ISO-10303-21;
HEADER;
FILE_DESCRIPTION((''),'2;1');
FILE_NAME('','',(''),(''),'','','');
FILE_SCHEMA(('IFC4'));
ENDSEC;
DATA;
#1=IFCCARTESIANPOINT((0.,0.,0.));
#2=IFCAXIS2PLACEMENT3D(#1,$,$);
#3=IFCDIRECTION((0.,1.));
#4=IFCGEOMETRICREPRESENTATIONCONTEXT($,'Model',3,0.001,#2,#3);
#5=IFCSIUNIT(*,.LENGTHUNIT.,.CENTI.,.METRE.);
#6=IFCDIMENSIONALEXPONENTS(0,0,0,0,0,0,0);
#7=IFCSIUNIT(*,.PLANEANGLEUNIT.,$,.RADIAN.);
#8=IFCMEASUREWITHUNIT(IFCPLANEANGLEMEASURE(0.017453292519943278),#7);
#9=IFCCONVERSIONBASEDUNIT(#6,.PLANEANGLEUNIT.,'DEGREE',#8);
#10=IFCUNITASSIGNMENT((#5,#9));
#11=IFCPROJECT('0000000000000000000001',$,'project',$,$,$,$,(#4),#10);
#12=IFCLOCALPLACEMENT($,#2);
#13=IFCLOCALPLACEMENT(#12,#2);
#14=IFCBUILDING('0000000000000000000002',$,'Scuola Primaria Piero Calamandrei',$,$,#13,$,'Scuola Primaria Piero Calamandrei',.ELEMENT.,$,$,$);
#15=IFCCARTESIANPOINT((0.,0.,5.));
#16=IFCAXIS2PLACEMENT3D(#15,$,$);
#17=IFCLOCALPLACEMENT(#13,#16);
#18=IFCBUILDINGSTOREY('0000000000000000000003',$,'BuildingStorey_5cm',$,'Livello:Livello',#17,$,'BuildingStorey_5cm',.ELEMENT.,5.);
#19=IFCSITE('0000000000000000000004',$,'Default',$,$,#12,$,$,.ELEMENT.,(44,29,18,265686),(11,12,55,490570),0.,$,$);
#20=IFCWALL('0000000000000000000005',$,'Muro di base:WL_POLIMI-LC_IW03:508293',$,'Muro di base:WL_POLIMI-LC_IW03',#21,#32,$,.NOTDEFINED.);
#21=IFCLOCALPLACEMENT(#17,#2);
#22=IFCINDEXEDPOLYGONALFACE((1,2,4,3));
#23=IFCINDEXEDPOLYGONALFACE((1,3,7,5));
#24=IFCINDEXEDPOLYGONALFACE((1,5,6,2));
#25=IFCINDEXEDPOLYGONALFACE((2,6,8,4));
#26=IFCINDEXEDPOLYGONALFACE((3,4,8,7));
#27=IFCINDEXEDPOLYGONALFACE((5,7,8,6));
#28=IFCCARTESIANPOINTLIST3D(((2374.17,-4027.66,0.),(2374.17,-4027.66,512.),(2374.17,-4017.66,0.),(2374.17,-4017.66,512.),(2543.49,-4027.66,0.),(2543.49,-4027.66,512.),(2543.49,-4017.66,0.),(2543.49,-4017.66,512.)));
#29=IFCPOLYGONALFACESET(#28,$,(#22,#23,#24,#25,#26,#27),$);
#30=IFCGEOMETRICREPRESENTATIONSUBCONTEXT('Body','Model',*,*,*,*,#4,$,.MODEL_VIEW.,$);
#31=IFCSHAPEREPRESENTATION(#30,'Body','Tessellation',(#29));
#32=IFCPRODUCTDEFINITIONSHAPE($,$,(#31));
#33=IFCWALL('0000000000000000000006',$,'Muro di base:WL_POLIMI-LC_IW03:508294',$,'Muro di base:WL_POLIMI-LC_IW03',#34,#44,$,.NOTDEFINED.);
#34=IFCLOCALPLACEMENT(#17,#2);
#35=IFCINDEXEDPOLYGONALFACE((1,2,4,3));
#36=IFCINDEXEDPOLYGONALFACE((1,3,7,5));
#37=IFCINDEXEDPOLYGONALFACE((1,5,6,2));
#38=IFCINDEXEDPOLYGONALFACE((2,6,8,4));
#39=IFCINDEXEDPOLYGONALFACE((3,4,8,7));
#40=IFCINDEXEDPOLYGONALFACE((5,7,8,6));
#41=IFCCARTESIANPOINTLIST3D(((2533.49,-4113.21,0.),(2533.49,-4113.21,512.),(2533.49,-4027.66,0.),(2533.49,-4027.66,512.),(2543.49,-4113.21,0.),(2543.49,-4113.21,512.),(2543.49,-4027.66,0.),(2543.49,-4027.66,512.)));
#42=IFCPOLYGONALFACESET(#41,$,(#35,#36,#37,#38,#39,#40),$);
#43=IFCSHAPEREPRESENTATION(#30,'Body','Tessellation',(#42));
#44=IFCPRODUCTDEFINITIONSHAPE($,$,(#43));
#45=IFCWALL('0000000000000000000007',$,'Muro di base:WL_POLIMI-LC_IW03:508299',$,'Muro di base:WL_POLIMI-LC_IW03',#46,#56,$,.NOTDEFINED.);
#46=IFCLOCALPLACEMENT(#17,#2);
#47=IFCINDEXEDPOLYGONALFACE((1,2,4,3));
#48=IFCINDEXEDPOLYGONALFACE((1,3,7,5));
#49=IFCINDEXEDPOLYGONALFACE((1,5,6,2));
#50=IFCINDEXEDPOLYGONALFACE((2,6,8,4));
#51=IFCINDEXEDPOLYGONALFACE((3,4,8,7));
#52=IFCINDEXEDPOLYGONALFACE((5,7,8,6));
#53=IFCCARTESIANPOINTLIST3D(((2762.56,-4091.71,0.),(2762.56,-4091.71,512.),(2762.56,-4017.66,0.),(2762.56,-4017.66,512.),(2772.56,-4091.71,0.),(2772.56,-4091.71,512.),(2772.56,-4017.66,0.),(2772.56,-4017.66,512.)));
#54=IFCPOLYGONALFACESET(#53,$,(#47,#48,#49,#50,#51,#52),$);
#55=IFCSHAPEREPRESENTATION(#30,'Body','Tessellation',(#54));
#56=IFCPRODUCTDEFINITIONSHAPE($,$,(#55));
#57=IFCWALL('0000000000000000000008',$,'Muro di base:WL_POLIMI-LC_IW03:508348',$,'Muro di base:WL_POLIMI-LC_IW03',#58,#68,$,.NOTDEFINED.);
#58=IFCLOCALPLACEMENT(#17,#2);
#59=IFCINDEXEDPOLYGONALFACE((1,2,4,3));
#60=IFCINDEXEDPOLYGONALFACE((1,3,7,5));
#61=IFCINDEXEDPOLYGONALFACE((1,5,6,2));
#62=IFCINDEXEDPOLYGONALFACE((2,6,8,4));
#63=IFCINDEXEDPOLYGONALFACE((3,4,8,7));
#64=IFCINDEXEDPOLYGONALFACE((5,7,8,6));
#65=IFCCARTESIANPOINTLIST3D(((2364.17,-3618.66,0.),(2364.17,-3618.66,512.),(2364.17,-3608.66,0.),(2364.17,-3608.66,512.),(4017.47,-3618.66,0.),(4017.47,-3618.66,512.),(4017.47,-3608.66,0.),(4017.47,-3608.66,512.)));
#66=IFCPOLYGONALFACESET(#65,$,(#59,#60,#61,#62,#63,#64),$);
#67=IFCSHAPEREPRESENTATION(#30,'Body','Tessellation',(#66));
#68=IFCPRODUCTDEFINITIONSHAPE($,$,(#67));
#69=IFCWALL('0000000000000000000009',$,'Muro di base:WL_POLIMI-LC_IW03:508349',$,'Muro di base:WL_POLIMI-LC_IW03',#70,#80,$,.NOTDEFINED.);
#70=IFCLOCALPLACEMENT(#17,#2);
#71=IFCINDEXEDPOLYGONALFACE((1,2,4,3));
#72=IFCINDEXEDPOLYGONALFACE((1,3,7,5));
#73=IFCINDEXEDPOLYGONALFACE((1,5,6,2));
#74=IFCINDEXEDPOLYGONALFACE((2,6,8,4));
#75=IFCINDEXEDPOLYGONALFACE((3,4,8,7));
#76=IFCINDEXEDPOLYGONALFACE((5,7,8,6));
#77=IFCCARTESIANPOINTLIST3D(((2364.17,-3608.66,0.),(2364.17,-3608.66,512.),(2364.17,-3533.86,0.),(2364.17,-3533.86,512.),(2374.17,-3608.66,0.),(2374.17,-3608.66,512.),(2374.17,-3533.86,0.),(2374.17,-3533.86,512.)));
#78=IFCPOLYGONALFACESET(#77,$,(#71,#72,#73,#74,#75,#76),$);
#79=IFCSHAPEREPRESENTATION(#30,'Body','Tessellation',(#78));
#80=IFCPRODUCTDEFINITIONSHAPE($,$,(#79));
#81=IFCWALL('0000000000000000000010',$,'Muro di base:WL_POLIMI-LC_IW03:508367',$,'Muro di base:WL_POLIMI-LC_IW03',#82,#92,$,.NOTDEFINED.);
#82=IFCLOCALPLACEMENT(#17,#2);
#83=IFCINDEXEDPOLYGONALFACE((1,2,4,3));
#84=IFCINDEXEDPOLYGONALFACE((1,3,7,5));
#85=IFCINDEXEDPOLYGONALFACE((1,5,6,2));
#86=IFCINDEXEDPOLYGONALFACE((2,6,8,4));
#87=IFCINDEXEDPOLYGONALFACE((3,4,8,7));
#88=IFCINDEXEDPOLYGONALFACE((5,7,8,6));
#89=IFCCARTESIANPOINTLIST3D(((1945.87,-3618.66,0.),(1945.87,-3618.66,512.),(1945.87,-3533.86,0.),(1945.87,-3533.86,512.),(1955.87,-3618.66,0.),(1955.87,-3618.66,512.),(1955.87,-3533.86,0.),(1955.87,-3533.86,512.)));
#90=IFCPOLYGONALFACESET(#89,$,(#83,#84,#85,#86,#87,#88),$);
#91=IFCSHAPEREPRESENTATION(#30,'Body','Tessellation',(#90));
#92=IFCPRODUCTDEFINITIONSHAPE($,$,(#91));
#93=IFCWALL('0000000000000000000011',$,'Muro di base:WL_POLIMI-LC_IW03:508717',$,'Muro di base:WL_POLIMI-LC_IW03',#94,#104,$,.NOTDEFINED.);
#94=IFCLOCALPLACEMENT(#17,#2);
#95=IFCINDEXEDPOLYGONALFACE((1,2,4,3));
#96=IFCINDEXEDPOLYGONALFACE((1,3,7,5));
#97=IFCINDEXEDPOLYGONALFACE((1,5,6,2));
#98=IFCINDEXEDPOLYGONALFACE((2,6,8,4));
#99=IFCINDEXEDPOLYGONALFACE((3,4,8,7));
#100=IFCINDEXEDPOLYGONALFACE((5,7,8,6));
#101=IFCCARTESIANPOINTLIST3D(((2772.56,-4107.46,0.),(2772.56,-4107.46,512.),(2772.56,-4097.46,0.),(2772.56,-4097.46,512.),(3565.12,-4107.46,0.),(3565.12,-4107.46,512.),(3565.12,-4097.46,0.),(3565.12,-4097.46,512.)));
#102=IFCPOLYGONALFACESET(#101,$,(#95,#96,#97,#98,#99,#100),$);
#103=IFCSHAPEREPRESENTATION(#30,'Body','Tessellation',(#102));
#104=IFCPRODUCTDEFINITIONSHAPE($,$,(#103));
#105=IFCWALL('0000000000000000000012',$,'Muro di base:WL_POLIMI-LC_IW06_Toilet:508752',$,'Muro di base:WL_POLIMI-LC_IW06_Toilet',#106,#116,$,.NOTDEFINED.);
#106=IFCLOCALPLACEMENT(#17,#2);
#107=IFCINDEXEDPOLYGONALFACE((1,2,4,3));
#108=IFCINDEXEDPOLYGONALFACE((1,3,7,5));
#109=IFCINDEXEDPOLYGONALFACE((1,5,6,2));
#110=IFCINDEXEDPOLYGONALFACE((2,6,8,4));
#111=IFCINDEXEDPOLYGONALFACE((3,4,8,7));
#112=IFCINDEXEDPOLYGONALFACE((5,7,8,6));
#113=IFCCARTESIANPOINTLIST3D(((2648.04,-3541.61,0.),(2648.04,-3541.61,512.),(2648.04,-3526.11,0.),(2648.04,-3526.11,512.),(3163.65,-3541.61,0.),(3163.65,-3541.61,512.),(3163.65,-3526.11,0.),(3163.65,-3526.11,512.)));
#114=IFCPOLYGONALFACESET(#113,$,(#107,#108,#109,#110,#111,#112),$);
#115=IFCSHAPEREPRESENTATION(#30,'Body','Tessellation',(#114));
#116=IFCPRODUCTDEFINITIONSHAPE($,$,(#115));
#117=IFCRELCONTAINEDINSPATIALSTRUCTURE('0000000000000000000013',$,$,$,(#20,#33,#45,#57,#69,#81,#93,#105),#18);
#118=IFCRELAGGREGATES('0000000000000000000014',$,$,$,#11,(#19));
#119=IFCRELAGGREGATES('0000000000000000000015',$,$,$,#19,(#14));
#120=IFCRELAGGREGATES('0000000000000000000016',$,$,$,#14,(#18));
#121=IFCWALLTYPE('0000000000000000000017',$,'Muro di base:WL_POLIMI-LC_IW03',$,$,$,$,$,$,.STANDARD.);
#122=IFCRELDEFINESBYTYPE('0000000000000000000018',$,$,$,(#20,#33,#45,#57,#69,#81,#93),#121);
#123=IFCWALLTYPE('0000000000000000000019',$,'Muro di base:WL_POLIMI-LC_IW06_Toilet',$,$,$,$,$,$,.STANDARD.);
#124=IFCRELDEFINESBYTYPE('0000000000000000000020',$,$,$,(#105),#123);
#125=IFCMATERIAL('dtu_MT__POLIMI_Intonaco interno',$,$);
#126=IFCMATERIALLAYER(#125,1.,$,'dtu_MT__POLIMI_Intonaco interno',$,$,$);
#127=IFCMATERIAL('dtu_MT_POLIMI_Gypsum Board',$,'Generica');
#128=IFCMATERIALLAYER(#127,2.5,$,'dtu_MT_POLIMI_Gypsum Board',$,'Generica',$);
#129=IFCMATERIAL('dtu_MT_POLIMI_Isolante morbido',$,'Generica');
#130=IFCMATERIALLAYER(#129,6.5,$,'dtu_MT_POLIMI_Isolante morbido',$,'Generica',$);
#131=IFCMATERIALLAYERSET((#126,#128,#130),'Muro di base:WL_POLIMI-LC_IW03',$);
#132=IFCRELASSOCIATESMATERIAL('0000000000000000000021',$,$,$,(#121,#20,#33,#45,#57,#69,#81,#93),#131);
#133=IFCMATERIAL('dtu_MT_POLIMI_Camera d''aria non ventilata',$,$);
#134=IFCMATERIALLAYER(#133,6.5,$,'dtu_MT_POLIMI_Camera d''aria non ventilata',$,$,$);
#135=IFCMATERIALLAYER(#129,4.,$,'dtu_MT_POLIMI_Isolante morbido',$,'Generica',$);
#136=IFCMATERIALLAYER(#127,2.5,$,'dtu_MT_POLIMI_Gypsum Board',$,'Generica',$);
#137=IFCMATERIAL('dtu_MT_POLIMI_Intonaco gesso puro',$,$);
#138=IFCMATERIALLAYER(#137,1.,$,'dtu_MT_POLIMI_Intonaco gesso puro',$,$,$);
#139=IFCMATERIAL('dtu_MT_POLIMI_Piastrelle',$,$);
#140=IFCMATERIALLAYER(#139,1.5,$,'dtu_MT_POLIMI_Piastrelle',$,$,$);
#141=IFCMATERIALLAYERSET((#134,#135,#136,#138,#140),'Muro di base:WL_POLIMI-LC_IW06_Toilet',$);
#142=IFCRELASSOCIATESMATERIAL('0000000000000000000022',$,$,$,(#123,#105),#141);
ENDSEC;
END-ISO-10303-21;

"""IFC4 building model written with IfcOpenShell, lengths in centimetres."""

from ifc_helpers import new_model, entity, si_unit, converted_unit, direction, frame, frame_2d, origin, place, context, subcontext, project, spatial, rectangle, extrude, material, layer, layer_set, layer_usage, type_object, element, save


model = new_model("IFC4")

# Units and contexts
model_context = context("Model", 3, precision=0.001, world=origin(), true_north=direction((0.0, 1.0)))
body_context = subcontext(model_context, "Body", "Model", "MODEL_VIEW")
ifc_project = project(units=[si_unit("LENGTHUNIT", "METRE", prefix="CENTI"), converted_unit("PLANEANGLEUNIT", "DEGREE", entity("IfcPlaneAngleMeasure", 0.017453292519943278), si_unit("PLANEANGLEUNIT", "RADIAN"), dimensions=[0, 0, 0, 0, 0, 0, 0])], contexts=[model_context])

# Site, building, storey
site_placement = place(None, origin())
site = spatial("IfcSite", under=ifc_project, at=site_placement, Name="Default", CompositionType="ELEMENT", RefLatitude=(44, 29, 18, 265686), RefLongitude=(11, 12, 55, 490570), RefElevation=0.0)
building_placement = place(site_placement, origin())
building = spatial("IfcBuilding", under=site, at=building_placement, Name="Scuola Primaria Piero Calamandrei", LongName="Scuola Primaria Piero Calamandrei", CompositionType="ELEMENT")
storey_placement = place(building_placement, frame((0.0, 0.0, 5.0)))
storey = spatial("IfcBuildingStorey", under=building, at=storey_placement, Name="BuildingStorey_5cm", ObjectType="Livello:Livello", LongName="BuildingStorey_5cm", CompositionType="ELEMENT", Elevation=5.0)

# Shared definitions
ifc_material_1 = material(Name="dtu_MT_POLIMI_Isolante morbido", Category="Generica")
ifc_material_2 = material(Name="dtu_MT_POLIMI_Gypsum Board", Category="Generica")
ifc_material_3 = material(Name="dtu_MT__POLIMI_Intonaco interno")
ifc_material_4 = material(Name="dtu_MT_POLIMI_Camera d'aria non ventilata")
ifc_material_5 = material(Name="dtu_MT_POLIMI_Intonaco gesso puro")

# Walls
ifc_layer_1 = layer(ifc_material_3, 1.0, Name="dtu_MT__POLIMI_Intonaco interno")
ifc_layer_2 = layer(ifc_material_2, 2.5, Name="dtu_MT_POLIMI_Gypsum Board", Category="Generica")
ifc_layer_3 = layer(ifc_material_1, 6.5, Name="dtu_MT_POLIMI_Isolante morbido", Category="Generica")
ifc_layer_set_1 = layer_set([ifc_layer_1, ifc_layer_2, ifc_layer_3], Name="Muro di base:WL_POLIMI-LC_IW03")
wall_type_1 = type_object("IfcWallType", Name="Muro di base:WL_POLIMI-LC_IW03", PredefinedType="STANDARD", material=ifc_layer_set_1)
ifc_layer_usage_1 = layer_usage(ifc_layer_set_1, "AXIS2", "NEGATIVE", 5.0)
wall_1_placement = place(storey_placement, frame((2543.49, -4022.66, 0.0), z_axis=(0.0, 0.0, 1.0), x_axis=(-1.0, 0.0, 0.0)))
element("IfcWall", 1, at=wall_1_placement, inside=storey, type_object=wall_type_1, material=ifc_layer_usage_1, Name="Muro di base:WL_POLIMI-LC_IW03:508293", ObjectType="Muro di base:WL_POLIMI-LC_IW03", PredefinedType="NOTDEFINED", context=body_context, shape_type="SweptSolid", body=[
    extrude(rectangle(XDim=169.31, YDim=10.0, at=frame_2d((84.66, 0.0), x_axis=(-1.0, 0.0))), origin(), (0.0, 0.0, 1.0), 512.0),
])
ifc_layer_usage_2 = layer_usage(ifc_layer_set_1, "AXIS2", "NEGATIVE", 5.0)
wall_2_placement = place(storey_placement, frame((2538.49, -4113.21, 0.0), z_axis=(0.0, 0.0, 1.0), x_axis=(0.0, 1.0, 0.0)))
element("IfcWall", 2, at=wall_2_placement, inside=storey, type_object=wall_type_1, material=ifc_layer_usage_2, Name="Muro di base:WL_POLIMI-LC_IW03:508294", ObjectType="Muro di base:WL_POLIMI-LC_IW03", PredefinedType="NOTDEFINED", context=body_context, shape_type="SweptSolid", body=[
    extrude(rectangle(XDim=85.55, YDim=10.0, at=frame_2d((42.78, 0.0), x_axis=(-1.0, 0.0))), origin(), (0.0, 0.0, 1.0), 512.0),
])
ifc_layer_usage_3 = layer_usage(ifc_layer_set_1, "AXIS2", "NEGATIVE", 5.0)
wall_3_placement = place(storey_placement, frame((2767.56, -4017.66, 0.0), z_axis=(0.0, 0.0, 1.0), x_axis=(0.0, -1.0, 0.0)))
element("IfcWall", 3, at=wall_3_placement, inside=storey, type_object=wall_type_1, material=ifc_layer_usage_3, Name="Muro di base:WL_POLIMI-LC_IW03:508299", ObjectType="Muro di base:WL_POLIMI-LC_IW03", PredefinedType="NOTDEFINED", context=body_context, shape_type="SweptSolid", body=[
    extrude(rectangle(XDim=74.05, YDim=10.0, at=frame_2d((37.03, 0.0), x_axis=(-1.0, 0.0))), origin(), (0.0, 0.0, 1.0), 512.0),
])
ifc_layer_usage_4 = layer_usage(ifc_layer_set_1, "AXIS2", "NEGATIVE", 5.0)
wall_4_placement = place(storey_placement, frame((2364.17, -3613.66, 0.0)))
element("IfcWall", 4, at=wall_4_placement, inside=storey, type_object=wall_type_1, material=ifc_layer_usage_4, Name="Muro di base:WL_POLIMI-LC_IW03:508348", ObjectType="Muro di base:WL_POLIMI-LC_IW03", PredefinedType="NOTDEFINED", context=body_context, shape_type="SweptSolid", body=[
    extrude(rectangle(XDim=1653.3, YDim=10.0, at=frame_2d((826.65, 0.0), x_axis=(-1.0, 0.0))), origin(), (0.0, 0.0, 1.0), 512.0),
])
ifc_layer_usage_5 = layer_usage(ifc_layer_set_1, "AXIS2", "NEGATIVE", 5.0)
wall_5_placement = place(storey_placement, frame((2369.17, -3533.86, 0.0), z_axis=(0.0, 0.0, 1.0), x_axis=(0.0, -1.0, 0.0)))
element("IfcWall", 5, at=wall_5_placement, inside=storey, type_object=wall_type_1, material=ifc_layer_usage_5, Name="Muro di base:WL_POLIMI-LC_IW03:508349", ObjectType="Muro di base:WL_POLIMI-LC_IW03", PredefinedType="NOTDEFINED", context=body_context, shape_type="SweptSolid", body=[
    extrude(rectangle(XDim=74.8, YDim=10.0, at=frame_2d((37.4, 0.0), x_axis=(-1.0, 0.0))), origin(), (0.0, 0.0, 1.0), 512.0),
])
ifc_layer_usage_6 = layer_usage(ifc_layer_set_1, "AXIS2", "NEGATIVE", 5.0)
wall_6_placement = place(storey_placement, frame((1950.87, -3618.66, 0.0), z_axis=(0.0, 0.0, 1.0), x_axis=(0.0, 1.0, 0.0)))
element("IfcWall", 6, at=wall_6_placement, inside=storey, type_object=wall_type_1, material=ifc_layer_usage_6, Name="Muro di base:WL_POLIMI-LC_IW03:508367", ObjectType="Muro di base:WL_POLIMI-LC_IW03", PredefinedType="NOTDEFINED", context=body_context, shape_type="SweptSolid", body=[
    extrude(rectangle(XDim=84.8, YDim=10.0, at=frame_2d((42.4, 0.0), x_axis=(-1.0, 0.0))), origin(), (0.0, 0.0, 1.0), 512.0),
])
ifc_layer_usage_7 = layer_usage(ifc_layer_set_1, "AXIS2", "NEGATIVE", 5.0)
wall_7_placement = place(storey_placement, frame((2772.56, -4102.46, 0.0)))
element("IfcWall", 7, at=wall_7_placement, inside=storey, type_object=wall_type_1, material=ifc_layer_usage_7, Name="Muro di base:WL_POLIMI-LC_IW03:508717", ObjectType="Muro di base:WL_POLIMI-LC_IW03", PredefinedType="NOTDEFINED", context=body_context, shape_type="SweptSolid", body=[
    extrude(rectangle(XDim=792.56, YDim=10.0, at=frame_2d((396.28, 0.0), x_axis=(-1.0, 0.0))), origin(), (0.0, 0.0, 1.0), 512.0),
])
ifc_layer_4 = layer(ifc_material_4, 6.5, Name="dtu_MT_POLIMI_Camera d'aria non ventilata")
ifc_layer_5 = layer(ifc_material_1, 4.0, Name="dtu_MT_POLIMI_Isolante morbido", Category="Generica")
ifc_layer_6 = layer(ifc_material_2, 2.5, Name="dtu_MT_POLIMI_Gypsum Board", Category="Generica")
ifc_layer_7 = layer(ifc_material_5, 1.0, Name="dtu_MT_POLIMI_Intonaco gesso puro")
ifc_material_6 = material(Name="dtu_MT_POLIMI_Piastrelle")
ifc_layer_8 = layer(ifc_material_6, 1.5, Name="dtu_MT_POLIMI_Piastrelle")
ifc_layer_set_2 = layer_set([ifc_layer_4, ifc_layer_5, ifc_layer_6, ifc_layer_7, ifc_layer_8], Name="Muro di base:WL_POLIMI-LC_IW06_Toilet")
ifc_layer_usage_8 = layer_usage(ifc_layer_set_2, "AXIS2", "NEGATIVE", 7.75)
wall_type_2 = type_object("IfcWallType", Name="Muro di base:WL_POLIMI-LC_IW06_Toilet", PredefinedType="STANDARD", material=ifc_layer_set_2)
wall_8_placement = place(storey_placement, frame((2648.04, -3533.86, 0.0)))
element("IfcWall", 8, at=wall_8_placement, inside=storey, type_object=wall_type_2, material=ifc_layer_usage_8, Name="Muro di base:WL_POLIMI-LC_IW06_Toilet:508752", ObjectType="Muro di base:WL_POLIMI-LC_IW06_Toilet", PredefinedType="NOTDEFINED", context=body_context, shape_type="SweptSolid", body=[
    extrude(rectangle(XDim=515.61, YDim=15.5, at=frame_2d((257.8, 0.0), x_axis=(-1.0, 0.0))), origin(), (0.0, 0.0, 1.0), 512.0),
])

save(model, "model.ifc")
